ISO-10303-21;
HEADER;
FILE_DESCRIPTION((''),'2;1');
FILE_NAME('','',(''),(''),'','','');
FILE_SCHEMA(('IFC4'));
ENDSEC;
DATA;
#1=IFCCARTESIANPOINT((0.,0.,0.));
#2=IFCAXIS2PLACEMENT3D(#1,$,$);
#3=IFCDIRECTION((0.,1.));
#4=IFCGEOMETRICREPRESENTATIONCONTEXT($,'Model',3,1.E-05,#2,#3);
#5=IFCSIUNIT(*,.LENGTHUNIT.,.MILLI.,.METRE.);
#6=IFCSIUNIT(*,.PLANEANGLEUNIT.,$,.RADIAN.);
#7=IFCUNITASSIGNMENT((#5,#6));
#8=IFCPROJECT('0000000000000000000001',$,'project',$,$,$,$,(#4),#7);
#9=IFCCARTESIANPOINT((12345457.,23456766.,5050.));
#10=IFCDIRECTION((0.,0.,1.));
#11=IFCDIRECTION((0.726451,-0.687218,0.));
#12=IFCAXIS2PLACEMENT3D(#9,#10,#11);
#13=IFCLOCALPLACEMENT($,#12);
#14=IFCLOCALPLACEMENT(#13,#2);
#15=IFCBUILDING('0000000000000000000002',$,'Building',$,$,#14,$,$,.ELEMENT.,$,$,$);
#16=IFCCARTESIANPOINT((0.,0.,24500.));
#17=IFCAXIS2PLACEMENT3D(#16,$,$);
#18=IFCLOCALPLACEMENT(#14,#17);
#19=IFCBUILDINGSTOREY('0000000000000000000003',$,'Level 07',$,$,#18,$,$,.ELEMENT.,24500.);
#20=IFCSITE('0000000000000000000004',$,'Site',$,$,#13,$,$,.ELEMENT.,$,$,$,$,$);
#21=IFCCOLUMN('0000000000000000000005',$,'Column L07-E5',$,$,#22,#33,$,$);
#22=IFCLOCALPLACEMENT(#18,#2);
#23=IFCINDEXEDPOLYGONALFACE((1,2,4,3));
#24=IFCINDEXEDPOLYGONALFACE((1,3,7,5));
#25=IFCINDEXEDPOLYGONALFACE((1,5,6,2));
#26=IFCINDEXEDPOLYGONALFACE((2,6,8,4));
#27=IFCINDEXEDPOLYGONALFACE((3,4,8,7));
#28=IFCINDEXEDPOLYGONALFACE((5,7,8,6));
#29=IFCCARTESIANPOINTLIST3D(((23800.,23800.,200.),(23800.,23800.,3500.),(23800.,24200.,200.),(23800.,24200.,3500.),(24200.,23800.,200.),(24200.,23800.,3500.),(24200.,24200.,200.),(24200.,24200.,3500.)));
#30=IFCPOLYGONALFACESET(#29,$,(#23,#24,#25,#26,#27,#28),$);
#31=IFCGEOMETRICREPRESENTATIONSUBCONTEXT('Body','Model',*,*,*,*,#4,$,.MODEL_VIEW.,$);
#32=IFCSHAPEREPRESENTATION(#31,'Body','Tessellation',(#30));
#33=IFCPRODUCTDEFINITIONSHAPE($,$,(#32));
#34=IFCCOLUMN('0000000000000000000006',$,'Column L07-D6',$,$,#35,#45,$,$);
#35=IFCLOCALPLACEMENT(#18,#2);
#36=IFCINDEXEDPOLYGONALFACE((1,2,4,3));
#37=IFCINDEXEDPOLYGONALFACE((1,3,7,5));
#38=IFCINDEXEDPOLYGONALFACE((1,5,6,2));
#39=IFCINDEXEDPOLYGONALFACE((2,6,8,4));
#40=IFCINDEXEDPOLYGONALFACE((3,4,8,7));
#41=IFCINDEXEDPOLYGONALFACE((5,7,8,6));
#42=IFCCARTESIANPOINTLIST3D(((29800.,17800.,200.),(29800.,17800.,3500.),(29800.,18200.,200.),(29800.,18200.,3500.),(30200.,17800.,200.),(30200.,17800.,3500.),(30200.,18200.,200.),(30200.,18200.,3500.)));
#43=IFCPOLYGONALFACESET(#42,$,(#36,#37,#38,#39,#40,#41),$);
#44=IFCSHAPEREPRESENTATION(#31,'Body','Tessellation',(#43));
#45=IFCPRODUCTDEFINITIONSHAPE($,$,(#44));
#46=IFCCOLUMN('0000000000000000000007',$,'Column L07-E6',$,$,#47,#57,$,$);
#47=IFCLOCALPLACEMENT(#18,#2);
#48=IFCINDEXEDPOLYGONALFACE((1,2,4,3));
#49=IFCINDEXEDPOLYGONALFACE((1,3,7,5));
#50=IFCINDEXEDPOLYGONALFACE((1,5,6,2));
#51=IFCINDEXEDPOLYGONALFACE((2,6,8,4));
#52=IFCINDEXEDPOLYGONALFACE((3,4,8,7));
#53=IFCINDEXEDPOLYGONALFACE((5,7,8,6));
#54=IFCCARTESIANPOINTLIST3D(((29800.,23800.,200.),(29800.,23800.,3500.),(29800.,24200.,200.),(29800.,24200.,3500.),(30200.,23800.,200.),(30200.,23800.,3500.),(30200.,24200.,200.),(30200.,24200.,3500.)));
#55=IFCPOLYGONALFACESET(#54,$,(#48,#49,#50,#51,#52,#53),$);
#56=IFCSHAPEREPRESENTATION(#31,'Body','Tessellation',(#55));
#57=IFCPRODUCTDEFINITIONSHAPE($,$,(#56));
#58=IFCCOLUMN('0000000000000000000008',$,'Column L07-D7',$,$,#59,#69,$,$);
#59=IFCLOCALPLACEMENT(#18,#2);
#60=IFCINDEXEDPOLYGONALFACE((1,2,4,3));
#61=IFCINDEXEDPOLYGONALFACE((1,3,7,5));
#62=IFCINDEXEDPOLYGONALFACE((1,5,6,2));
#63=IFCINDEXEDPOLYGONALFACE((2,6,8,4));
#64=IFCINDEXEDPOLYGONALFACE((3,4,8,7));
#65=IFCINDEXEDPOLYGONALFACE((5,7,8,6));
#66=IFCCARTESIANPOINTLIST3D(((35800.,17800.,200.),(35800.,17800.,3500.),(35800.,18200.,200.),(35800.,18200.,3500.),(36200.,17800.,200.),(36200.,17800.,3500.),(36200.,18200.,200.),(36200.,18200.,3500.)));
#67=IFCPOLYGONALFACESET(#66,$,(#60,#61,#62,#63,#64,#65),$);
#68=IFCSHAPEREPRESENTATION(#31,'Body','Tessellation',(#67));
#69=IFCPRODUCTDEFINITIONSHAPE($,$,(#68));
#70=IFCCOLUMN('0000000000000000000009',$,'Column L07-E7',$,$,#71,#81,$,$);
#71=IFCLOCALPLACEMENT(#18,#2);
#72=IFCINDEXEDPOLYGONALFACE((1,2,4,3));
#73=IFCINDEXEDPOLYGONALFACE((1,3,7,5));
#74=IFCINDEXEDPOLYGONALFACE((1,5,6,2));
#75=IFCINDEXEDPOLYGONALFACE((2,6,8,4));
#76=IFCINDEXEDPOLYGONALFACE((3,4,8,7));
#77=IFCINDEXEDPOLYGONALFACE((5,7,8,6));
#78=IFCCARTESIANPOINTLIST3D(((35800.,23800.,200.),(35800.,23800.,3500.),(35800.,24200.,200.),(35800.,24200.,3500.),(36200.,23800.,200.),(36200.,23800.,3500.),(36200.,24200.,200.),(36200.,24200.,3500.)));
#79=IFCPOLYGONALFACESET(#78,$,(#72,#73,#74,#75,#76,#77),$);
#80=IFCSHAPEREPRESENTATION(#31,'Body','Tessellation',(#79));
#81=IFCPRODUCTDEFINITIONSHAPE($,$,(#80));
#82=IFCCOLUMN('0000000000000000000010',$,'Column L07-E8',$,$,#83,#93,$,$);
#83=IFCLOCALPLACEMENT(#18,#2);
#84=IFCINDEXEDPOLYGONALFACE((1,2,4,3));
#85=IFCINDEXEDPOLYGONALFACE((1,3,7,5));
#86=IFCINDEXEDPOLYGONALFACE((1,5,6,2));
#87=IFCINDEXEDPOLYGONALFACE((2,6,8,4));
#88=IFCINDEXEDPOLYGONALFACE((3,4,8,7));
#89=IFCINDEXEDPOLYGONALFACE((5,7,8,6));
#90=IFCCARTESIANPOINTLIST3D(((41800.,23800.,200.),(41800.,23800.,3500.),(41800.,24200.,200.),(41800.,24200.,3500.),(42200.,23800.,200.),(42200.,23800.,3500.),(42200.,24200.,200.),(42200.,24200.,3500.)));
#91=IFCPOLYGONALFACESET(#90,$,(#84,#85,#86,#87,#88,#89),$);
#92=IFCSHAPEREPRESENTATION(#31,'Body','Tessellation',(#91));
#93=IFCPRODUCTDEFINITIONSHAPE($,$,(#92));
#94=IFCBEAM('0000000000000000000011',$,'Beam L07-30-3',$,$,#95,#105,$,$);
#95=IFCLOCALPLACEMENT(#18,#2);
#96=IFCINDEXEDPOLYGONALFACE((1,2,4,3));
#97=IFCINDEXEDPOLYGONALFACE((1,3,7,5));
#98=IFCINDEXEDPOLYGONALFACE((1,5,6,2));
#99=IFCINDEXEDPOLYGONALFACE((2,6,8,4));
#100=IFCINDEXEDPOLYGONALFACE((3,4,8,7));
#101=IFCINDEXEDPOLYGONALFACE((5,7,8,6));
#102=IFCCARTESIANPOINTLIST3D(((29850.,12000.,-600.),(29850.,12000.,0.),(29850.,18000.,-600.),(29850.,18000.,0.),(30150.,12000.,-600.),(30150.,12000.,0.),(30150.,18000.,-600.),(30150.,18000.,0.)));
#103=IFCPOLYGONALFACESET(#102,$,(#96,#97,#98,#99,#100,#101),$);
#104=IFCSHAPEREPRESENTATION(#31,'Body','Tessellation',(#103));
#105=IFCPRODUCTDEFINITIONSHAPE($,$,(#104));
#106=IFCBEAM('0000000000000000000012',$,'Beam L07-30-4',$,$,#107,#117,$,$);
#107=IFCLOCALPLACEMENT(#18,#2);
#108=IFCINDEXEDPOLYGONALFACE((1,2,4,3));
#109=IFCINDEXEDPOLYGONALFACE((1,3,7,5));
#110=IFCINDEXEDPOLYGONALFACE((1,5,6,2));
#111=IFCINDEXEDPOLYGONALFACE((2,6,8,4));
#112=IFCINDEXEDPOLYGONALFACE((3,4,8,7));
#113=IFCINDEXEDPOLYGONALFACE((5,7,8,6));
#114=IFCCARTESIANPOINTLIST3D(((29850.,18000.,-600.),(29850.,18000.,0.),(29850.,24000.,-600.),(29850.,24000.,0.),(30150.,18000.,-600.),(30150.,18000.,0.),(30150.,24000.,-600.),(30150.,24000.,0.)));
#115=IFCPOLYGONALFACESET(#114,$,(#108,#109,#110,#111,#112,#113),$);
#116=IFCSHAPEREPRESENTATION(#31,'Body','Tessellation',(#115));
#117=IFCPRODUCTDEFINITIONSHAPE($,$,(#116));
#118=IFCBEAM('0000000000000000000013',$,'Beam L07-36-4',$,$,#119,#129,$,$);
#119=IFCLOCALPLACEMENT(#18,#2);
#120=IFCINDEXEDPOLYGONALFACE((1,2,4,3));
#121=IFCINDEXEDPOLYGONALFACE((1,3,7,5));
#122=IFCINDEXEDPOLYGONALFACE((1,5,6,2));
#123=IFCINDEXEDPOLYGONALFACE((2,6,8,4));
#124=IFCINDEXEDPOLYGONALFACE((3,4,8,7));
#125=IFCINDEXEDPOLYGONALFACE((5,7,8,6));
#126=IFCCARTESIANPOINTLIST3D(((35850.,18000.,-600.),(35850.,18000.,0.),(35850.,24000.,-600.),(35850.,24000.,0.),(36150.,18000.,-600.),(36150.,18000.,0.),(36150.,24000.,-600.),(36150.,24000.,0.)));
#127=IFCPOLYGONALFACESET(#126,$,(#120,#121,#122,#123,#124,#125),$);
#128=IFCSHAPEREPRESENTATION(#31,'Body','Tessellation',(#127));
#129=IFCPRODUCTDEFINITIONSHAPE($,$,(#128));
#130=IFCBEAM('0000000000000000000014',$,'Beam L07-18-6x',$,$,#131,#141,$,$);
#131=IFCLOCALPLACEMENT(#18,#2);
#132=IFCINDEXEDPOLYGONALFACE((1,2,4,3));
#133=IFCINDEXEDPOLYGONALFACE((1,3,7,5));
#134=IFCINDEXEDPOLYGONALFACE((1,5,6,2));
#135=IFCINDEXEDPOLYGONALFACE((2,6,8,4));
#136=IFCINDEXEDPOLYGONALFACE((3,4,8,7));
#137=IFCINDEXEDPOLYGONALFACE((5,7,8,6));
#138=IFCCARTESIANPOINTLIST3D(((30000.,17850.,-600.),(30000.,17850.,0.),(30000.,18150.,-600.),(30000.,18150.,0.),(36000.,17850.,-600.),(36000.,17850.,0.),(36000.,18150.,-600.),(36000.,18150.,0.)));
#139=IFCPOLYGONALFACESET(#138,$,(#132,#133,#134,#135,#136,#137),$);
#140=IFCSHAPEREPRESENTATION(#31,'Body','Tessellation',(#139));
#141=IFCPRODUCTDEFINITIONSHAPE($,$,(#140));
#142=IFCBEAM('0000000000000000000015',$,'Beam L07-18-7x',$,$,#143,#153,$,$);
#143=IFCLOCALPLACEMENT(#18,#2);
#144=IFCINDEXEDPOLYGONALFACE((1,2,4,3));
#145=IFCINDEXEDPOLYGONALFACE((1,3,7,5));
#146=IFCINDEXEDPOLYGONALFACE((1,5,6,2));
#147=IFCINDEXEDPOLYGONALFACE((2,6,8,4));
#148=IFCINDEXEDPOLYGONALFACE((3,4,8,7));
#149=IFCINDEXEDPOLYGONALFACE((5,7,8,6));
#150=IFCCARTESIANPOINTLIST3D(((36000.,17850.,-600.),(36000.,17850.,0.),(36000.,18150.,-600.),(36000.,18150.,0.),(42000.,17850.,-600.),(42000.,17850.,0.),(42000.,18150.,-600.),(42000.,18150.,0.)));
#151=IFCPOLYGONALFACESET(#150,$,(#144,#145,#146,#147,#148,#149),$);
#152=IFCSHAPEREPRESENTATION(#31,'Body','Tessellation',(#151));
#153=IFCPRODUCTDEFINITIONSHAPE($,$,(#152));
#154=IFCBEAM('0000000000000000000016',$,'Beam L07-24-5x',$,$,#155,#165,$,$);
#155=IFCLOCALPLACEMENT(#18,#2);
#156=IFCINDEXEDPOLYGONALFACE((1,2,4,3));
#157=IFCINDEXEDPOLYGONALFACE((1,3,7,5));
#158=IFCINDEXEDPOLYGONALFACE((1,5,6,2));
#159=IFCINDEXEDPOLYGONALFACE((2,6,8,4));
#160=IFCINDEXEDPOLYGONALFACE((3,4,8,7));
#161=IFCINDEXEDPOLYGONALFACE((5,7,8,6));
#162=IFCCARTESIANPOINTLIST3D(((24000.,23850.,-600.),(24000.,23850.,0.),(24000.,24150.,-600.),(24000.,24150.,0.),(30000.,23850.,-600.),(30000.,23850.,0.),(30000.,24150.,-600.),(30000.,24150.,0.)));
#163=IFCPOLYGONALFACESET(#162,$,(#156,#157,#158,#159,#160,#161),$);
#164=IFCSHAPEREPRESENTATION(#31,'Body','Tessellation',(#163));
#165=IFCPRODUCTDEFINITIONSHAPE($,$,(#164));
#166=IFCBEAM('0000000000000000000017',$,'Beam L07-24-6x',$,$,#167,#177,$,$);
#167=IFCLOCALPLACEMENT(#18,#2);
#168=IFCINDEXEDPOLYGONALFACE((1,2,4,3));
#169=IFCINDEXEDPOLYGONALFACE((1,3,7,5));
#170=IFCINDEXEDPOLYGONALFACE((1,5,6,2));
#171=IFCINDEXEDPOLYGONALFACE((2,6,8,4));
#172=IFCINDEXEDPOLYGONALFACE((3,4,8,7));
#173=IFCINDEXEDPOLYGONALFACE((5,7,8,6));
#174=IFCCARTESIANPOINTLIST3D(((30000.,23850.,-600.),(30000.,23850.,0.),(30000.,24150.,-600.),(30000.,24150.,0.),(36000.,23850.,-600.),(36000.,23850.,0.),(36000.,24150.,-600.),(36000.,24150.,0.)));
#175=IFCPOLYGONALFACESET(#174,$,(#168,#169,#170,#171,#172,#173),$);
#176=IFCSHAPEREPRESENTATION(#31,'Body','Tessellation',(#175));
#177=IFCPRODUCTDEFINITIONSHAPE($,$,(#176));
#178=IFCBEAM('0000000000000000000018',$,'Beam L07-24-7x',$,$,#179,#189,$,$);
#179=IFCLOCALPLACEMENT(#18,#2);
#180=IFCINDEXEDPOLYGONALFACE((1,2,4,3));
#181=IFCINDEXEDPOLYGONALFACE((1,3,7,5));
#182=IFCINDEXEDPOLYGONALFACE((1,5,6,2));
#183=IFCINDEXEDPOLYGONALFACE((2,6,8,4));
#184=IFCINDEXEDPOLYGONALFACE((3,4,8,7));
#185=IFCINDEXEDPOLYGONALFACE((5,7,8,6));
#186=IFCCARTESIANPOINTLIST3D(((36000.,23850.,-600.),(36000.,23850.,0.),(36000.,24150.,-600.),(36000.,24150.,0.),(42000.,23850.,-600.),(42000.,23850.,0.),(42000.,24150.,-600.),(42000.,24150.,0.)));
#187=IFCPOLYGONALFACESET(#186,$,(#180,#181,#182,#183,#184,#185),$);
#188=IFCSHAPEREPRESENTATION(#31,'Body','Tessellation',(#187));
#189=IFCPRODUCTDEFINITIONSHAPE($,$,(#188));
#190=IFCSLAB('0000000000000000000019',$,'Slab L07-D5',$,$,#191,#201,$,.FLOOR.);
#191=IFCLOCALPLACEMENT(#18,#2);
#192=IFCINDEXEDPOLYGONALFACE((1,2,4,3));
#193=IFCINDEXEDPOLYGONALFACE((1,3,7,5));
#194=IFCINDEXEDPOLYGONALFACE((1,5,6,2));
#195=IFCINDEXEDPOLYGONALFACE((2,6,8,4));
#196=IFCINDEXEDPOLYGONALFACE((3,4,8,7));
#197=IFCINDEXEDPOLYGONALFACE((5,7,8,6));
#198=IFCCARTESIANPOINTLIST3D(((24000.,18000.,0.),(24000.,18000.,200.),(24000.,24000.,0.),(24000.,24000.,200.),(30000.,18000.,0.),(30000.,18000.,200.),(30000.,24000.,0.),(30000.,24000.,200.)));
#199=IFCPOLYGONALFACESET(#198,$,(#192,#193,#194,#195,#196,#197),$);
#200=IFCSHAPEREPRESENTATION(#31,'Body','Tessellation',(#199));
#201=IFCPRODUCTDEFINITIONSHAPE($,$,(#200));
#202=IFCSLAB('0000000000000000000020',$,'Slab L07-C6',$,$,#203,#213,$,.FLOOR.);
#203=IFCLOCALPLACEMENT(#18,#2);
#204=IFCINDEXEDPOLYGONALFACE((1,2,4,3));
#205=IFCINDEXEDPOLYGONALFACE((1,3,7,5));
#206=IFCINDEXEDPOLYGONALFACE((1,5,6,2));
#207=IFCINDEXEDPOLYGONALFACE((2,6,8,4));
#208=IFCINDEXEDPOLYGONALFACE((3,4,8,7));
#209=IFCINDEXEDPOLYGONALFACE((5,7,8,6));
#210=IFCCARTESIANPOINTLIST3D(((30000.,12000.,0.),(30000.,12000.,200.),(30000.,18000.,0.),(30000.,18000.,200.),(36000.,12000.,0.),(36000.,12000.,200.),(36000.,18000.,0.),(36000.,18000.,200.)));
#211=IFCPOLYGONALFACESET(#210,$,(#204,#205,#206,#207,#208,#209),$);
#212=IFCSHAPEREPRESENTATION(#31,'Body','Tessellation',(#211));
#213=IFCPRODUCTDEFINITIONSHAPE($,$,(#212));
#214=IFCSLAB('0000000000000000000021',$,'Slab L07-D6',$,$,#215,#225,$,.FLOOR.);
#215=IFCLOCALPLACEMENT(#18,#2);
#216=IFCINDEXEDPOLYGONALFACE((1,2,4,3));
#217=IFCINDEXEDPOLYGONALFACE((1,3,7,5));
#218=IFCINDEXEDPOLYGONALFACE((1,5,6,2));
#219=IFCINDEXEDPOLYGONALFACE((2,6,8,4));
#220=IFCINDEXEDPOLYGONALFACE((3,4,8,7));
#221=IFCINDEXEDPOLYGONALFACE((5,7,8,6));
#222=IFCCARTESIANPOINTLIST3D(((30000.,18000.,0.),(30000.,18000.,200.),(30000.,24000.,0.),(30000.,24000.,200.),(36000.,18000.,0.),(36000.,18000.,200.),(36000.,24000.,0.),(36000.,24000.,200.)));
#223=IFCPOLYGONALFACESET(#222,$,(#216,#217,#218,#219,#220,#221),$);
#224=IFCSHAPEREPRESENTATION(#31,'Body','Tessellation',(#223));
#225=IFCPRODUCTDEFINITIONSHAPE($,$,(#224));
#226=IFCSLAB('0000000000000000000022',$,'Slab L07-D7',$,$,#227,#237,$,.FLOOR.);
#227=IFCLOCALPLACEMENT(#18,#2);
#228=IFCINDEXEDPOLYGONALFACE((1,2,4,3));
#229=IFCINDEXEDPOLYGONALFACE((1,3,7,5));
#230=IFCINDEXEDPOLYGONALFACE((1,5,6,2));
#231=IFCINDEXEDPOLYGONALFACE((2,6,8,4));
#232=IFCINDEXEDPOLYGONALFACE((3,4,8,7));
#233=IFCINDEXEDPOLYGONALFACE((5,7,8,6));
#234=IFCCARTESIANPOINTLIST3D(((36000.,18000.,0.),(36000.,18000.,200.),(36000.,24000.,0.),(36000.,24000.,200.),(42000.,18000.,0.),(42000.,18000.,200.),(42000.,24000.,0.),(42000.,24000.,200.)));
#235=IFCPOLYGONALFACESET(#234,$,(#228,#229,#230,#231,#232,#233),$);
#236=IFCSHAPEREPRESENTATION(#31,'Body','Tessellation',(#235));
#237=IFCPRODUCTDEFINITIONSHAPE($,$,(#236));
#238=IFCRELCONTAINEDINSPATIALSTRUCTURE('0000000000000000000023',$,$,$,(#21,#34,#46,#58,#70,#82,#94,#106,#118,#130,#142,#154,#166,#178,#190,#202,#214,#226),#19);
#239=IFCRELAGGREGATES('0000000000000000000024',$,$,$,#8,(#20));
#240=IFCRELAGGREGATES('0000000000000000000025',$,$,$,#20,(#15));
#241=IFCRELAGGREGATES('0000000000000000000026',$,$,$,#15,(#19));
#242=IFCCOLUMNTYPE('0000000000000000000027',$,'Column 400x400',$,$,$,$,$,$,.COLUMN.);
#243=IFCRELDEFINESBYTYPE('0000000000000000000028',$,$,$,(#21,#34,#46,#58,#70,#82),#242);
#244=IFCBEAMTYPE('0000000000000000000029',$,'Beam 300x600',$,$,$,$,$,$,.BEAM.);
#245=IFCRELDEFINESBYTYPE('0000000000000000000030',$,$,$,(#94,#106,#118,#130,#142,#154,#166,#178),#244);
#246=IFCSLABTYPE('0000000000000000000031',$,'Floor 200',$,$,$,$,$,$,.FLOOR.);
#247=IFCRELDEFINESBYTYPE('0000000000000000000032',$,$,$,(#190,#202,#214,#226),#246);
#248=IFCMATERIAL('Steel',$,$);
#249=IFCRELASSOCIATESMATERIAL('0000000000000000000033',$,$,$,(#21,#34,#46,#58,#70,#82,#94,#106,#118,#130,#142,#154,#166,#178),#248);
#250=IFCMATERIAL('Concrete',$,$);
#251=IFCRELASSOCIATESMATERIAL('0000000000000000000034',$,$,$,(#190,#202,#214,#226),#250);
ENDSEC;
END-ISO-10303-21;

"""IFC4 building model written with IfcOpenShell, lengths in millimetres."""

from ifc_helpers import new_model, si_unit, direction, frame, origin, place, context, subcontext, project, spatial, rectangle, extrude, material, type_object, element, save


model = new_model("IFC4")

# Units and contexts
model_context = context("Model", 3, precision=1e-05, world=origin(), true_north=direction((0.0, 1.0)))
body_context = subcontext(model_context, "Body", "Model", "MODEL_VIEW")
ifc_project = project(units=[si_unit("LENGTHUNIT", "METRE", prefix="MILLI"), si_unit("PLANEANGLEUNIT", "RADIAN")], contexts=[model_context])

# Site, building, storey
site_placement = place(None, frame((12345457.0, 23456766.0, 5050.0), z_axis=(0.0, 0.0, 1.0), x_axis=(0.726451, -0.687218, 0.0)))
site = spatial("IfcSite", under=ifc_project, at=site_placement, Name="Site", CompositionType="ELEMENT")
building_placement = place(site_placement, origin())
building = spatial("IfcBuilding", under=site, at=building_placement, Name="Building", CompositionType="ELEMENT")
storey_placement = place(building_placement, frame((0.0, 0.0, 24500.0)))
storey = spatial("IfcBuildingStorey", under=building, at=storey_placement, Name="Level 07", CompositionType="ELEMENT", Elevation=24500.0)

# Columns
ifc_material_1 = material(Name="Steel")
column_type = type_object("IfcColumnType", Name="Column 400x400", PredefinedType="COLUMN")
for number, where, name in (
    (1, (23800.0, 23800.0, 200.0), "Column L07-E5"),
    (2, (29800.0, 17800.0, 200.0), "Column L07-D6"),
    (3, (29800.0, 23800.0, 200.0), "Column L07-E6"),
    (4, (35800.0, 17800.0, 200.0), "Column L07-D7"),
    (5, (35800.0, 23800.0, 200.0), "Column L07-E7"),
    (6, (41800.0, 23800.0, 200.0), "Column L07-E8"),
):
    element("IfcColumn", number, at=place(storey_placement, frame(where)), inside=storey, type_object=column_type, material=ifc_material_1, Name=name, context=body_context, shape_type="SweptSolid", body=[
        extrude(rectangle(XDim=400.0, YDim=400.0), frame((200.0, 200.0, 0.0)), (0.0, 0.0, 1.0), 3300.0),
    ])

# Beams
beam_type = type_object("IfcBeamType", Name="Beam 300x600", PredefinedType="BEAM")
for number, where, name in (
    (7, (29850.0, 12000.0, -600.0), "Beam L07-30-3"),
    (8, (29850.0, 18000.0, -600.0), "Beam L07-30-4"),
    (9, (35850.0, 18000.0, -600.0), "Beam L07-36-4"),
):
    element("IfcBeam", number, at=place(storey_placement, frame(where)), inside=storey, type_object=beam_type, material=ifc_material_1, Name=name, context=body_context, shape_type="SweptSolid", body=[
        extrude(rectangle(XDim=300.0, YDim=6000.0), frame((150.0, 3000.0, 0.0)), (0.0, 0.0, 1.0), 600.0),
    ])
for number, where, name in (
    (10, (30000.0, 17850.0, -600.0), "Beam L07-18-6x"),
    (11, (36000.0, 17850.0, -600.0), "Beam L07-18-7x"),
    (12, (24000.0, 23850.0, -600.0), "Beam L07-24-5x"),
    (13, (30000.0, 23850.0, -600.0), "Beam L07-24-6x"),
    (14, (36000.0, 23850.0, -600.0), "Beam L07-24-7x"),
):
    element("IfcBeam", number, at=place(storey_placement, frame(where)), inside=storey, type_object=beam_type, material=ifc_material_1, Name=name, context=body_context, shape_type="SweptSolid", body=[
        extrude(rectangle(XDim=6000.0, YDim=300.0), frame((3000.0, 150.0, 0.0)), (0.0, 0.0, 1.0), 600.0),
    ])

# Slabs
ifc_material_2 = material(Name="Concrete")
slab_type = type_object("IfcSlabType", Name="Floor 200", PredefinedType="FLOOR")
for number, where, name in (
    (15, (24000.0, 18000.0, 0.0), "Slab L07-D5"),
    (16, (30000.0, 12000.0, 0.0), "Slab L07-C6"),
    (17, (30000.0, 18000.0, 0.0), "Slab L07-D6"),
    (18, (36000.0, 18000.0, 0.0), "Slab L07-D7"),
):
    element("IfcSlab", number, at=place(storey_placement, frame(where)), inside=storey, type_object=slab_type, material=ifc_material_2, Name=name, PredefinedType="FLOOR", context=body_context, shape_type="SweptSolid", body=[
        extrude(rectangle(XDim=6000.0, YDim=6000.0), frame((3000.0, 3000.0, 0.0)), (0.0, 0.0, 1.0), 200.0),
    ])

save(model, "model.ifc")
